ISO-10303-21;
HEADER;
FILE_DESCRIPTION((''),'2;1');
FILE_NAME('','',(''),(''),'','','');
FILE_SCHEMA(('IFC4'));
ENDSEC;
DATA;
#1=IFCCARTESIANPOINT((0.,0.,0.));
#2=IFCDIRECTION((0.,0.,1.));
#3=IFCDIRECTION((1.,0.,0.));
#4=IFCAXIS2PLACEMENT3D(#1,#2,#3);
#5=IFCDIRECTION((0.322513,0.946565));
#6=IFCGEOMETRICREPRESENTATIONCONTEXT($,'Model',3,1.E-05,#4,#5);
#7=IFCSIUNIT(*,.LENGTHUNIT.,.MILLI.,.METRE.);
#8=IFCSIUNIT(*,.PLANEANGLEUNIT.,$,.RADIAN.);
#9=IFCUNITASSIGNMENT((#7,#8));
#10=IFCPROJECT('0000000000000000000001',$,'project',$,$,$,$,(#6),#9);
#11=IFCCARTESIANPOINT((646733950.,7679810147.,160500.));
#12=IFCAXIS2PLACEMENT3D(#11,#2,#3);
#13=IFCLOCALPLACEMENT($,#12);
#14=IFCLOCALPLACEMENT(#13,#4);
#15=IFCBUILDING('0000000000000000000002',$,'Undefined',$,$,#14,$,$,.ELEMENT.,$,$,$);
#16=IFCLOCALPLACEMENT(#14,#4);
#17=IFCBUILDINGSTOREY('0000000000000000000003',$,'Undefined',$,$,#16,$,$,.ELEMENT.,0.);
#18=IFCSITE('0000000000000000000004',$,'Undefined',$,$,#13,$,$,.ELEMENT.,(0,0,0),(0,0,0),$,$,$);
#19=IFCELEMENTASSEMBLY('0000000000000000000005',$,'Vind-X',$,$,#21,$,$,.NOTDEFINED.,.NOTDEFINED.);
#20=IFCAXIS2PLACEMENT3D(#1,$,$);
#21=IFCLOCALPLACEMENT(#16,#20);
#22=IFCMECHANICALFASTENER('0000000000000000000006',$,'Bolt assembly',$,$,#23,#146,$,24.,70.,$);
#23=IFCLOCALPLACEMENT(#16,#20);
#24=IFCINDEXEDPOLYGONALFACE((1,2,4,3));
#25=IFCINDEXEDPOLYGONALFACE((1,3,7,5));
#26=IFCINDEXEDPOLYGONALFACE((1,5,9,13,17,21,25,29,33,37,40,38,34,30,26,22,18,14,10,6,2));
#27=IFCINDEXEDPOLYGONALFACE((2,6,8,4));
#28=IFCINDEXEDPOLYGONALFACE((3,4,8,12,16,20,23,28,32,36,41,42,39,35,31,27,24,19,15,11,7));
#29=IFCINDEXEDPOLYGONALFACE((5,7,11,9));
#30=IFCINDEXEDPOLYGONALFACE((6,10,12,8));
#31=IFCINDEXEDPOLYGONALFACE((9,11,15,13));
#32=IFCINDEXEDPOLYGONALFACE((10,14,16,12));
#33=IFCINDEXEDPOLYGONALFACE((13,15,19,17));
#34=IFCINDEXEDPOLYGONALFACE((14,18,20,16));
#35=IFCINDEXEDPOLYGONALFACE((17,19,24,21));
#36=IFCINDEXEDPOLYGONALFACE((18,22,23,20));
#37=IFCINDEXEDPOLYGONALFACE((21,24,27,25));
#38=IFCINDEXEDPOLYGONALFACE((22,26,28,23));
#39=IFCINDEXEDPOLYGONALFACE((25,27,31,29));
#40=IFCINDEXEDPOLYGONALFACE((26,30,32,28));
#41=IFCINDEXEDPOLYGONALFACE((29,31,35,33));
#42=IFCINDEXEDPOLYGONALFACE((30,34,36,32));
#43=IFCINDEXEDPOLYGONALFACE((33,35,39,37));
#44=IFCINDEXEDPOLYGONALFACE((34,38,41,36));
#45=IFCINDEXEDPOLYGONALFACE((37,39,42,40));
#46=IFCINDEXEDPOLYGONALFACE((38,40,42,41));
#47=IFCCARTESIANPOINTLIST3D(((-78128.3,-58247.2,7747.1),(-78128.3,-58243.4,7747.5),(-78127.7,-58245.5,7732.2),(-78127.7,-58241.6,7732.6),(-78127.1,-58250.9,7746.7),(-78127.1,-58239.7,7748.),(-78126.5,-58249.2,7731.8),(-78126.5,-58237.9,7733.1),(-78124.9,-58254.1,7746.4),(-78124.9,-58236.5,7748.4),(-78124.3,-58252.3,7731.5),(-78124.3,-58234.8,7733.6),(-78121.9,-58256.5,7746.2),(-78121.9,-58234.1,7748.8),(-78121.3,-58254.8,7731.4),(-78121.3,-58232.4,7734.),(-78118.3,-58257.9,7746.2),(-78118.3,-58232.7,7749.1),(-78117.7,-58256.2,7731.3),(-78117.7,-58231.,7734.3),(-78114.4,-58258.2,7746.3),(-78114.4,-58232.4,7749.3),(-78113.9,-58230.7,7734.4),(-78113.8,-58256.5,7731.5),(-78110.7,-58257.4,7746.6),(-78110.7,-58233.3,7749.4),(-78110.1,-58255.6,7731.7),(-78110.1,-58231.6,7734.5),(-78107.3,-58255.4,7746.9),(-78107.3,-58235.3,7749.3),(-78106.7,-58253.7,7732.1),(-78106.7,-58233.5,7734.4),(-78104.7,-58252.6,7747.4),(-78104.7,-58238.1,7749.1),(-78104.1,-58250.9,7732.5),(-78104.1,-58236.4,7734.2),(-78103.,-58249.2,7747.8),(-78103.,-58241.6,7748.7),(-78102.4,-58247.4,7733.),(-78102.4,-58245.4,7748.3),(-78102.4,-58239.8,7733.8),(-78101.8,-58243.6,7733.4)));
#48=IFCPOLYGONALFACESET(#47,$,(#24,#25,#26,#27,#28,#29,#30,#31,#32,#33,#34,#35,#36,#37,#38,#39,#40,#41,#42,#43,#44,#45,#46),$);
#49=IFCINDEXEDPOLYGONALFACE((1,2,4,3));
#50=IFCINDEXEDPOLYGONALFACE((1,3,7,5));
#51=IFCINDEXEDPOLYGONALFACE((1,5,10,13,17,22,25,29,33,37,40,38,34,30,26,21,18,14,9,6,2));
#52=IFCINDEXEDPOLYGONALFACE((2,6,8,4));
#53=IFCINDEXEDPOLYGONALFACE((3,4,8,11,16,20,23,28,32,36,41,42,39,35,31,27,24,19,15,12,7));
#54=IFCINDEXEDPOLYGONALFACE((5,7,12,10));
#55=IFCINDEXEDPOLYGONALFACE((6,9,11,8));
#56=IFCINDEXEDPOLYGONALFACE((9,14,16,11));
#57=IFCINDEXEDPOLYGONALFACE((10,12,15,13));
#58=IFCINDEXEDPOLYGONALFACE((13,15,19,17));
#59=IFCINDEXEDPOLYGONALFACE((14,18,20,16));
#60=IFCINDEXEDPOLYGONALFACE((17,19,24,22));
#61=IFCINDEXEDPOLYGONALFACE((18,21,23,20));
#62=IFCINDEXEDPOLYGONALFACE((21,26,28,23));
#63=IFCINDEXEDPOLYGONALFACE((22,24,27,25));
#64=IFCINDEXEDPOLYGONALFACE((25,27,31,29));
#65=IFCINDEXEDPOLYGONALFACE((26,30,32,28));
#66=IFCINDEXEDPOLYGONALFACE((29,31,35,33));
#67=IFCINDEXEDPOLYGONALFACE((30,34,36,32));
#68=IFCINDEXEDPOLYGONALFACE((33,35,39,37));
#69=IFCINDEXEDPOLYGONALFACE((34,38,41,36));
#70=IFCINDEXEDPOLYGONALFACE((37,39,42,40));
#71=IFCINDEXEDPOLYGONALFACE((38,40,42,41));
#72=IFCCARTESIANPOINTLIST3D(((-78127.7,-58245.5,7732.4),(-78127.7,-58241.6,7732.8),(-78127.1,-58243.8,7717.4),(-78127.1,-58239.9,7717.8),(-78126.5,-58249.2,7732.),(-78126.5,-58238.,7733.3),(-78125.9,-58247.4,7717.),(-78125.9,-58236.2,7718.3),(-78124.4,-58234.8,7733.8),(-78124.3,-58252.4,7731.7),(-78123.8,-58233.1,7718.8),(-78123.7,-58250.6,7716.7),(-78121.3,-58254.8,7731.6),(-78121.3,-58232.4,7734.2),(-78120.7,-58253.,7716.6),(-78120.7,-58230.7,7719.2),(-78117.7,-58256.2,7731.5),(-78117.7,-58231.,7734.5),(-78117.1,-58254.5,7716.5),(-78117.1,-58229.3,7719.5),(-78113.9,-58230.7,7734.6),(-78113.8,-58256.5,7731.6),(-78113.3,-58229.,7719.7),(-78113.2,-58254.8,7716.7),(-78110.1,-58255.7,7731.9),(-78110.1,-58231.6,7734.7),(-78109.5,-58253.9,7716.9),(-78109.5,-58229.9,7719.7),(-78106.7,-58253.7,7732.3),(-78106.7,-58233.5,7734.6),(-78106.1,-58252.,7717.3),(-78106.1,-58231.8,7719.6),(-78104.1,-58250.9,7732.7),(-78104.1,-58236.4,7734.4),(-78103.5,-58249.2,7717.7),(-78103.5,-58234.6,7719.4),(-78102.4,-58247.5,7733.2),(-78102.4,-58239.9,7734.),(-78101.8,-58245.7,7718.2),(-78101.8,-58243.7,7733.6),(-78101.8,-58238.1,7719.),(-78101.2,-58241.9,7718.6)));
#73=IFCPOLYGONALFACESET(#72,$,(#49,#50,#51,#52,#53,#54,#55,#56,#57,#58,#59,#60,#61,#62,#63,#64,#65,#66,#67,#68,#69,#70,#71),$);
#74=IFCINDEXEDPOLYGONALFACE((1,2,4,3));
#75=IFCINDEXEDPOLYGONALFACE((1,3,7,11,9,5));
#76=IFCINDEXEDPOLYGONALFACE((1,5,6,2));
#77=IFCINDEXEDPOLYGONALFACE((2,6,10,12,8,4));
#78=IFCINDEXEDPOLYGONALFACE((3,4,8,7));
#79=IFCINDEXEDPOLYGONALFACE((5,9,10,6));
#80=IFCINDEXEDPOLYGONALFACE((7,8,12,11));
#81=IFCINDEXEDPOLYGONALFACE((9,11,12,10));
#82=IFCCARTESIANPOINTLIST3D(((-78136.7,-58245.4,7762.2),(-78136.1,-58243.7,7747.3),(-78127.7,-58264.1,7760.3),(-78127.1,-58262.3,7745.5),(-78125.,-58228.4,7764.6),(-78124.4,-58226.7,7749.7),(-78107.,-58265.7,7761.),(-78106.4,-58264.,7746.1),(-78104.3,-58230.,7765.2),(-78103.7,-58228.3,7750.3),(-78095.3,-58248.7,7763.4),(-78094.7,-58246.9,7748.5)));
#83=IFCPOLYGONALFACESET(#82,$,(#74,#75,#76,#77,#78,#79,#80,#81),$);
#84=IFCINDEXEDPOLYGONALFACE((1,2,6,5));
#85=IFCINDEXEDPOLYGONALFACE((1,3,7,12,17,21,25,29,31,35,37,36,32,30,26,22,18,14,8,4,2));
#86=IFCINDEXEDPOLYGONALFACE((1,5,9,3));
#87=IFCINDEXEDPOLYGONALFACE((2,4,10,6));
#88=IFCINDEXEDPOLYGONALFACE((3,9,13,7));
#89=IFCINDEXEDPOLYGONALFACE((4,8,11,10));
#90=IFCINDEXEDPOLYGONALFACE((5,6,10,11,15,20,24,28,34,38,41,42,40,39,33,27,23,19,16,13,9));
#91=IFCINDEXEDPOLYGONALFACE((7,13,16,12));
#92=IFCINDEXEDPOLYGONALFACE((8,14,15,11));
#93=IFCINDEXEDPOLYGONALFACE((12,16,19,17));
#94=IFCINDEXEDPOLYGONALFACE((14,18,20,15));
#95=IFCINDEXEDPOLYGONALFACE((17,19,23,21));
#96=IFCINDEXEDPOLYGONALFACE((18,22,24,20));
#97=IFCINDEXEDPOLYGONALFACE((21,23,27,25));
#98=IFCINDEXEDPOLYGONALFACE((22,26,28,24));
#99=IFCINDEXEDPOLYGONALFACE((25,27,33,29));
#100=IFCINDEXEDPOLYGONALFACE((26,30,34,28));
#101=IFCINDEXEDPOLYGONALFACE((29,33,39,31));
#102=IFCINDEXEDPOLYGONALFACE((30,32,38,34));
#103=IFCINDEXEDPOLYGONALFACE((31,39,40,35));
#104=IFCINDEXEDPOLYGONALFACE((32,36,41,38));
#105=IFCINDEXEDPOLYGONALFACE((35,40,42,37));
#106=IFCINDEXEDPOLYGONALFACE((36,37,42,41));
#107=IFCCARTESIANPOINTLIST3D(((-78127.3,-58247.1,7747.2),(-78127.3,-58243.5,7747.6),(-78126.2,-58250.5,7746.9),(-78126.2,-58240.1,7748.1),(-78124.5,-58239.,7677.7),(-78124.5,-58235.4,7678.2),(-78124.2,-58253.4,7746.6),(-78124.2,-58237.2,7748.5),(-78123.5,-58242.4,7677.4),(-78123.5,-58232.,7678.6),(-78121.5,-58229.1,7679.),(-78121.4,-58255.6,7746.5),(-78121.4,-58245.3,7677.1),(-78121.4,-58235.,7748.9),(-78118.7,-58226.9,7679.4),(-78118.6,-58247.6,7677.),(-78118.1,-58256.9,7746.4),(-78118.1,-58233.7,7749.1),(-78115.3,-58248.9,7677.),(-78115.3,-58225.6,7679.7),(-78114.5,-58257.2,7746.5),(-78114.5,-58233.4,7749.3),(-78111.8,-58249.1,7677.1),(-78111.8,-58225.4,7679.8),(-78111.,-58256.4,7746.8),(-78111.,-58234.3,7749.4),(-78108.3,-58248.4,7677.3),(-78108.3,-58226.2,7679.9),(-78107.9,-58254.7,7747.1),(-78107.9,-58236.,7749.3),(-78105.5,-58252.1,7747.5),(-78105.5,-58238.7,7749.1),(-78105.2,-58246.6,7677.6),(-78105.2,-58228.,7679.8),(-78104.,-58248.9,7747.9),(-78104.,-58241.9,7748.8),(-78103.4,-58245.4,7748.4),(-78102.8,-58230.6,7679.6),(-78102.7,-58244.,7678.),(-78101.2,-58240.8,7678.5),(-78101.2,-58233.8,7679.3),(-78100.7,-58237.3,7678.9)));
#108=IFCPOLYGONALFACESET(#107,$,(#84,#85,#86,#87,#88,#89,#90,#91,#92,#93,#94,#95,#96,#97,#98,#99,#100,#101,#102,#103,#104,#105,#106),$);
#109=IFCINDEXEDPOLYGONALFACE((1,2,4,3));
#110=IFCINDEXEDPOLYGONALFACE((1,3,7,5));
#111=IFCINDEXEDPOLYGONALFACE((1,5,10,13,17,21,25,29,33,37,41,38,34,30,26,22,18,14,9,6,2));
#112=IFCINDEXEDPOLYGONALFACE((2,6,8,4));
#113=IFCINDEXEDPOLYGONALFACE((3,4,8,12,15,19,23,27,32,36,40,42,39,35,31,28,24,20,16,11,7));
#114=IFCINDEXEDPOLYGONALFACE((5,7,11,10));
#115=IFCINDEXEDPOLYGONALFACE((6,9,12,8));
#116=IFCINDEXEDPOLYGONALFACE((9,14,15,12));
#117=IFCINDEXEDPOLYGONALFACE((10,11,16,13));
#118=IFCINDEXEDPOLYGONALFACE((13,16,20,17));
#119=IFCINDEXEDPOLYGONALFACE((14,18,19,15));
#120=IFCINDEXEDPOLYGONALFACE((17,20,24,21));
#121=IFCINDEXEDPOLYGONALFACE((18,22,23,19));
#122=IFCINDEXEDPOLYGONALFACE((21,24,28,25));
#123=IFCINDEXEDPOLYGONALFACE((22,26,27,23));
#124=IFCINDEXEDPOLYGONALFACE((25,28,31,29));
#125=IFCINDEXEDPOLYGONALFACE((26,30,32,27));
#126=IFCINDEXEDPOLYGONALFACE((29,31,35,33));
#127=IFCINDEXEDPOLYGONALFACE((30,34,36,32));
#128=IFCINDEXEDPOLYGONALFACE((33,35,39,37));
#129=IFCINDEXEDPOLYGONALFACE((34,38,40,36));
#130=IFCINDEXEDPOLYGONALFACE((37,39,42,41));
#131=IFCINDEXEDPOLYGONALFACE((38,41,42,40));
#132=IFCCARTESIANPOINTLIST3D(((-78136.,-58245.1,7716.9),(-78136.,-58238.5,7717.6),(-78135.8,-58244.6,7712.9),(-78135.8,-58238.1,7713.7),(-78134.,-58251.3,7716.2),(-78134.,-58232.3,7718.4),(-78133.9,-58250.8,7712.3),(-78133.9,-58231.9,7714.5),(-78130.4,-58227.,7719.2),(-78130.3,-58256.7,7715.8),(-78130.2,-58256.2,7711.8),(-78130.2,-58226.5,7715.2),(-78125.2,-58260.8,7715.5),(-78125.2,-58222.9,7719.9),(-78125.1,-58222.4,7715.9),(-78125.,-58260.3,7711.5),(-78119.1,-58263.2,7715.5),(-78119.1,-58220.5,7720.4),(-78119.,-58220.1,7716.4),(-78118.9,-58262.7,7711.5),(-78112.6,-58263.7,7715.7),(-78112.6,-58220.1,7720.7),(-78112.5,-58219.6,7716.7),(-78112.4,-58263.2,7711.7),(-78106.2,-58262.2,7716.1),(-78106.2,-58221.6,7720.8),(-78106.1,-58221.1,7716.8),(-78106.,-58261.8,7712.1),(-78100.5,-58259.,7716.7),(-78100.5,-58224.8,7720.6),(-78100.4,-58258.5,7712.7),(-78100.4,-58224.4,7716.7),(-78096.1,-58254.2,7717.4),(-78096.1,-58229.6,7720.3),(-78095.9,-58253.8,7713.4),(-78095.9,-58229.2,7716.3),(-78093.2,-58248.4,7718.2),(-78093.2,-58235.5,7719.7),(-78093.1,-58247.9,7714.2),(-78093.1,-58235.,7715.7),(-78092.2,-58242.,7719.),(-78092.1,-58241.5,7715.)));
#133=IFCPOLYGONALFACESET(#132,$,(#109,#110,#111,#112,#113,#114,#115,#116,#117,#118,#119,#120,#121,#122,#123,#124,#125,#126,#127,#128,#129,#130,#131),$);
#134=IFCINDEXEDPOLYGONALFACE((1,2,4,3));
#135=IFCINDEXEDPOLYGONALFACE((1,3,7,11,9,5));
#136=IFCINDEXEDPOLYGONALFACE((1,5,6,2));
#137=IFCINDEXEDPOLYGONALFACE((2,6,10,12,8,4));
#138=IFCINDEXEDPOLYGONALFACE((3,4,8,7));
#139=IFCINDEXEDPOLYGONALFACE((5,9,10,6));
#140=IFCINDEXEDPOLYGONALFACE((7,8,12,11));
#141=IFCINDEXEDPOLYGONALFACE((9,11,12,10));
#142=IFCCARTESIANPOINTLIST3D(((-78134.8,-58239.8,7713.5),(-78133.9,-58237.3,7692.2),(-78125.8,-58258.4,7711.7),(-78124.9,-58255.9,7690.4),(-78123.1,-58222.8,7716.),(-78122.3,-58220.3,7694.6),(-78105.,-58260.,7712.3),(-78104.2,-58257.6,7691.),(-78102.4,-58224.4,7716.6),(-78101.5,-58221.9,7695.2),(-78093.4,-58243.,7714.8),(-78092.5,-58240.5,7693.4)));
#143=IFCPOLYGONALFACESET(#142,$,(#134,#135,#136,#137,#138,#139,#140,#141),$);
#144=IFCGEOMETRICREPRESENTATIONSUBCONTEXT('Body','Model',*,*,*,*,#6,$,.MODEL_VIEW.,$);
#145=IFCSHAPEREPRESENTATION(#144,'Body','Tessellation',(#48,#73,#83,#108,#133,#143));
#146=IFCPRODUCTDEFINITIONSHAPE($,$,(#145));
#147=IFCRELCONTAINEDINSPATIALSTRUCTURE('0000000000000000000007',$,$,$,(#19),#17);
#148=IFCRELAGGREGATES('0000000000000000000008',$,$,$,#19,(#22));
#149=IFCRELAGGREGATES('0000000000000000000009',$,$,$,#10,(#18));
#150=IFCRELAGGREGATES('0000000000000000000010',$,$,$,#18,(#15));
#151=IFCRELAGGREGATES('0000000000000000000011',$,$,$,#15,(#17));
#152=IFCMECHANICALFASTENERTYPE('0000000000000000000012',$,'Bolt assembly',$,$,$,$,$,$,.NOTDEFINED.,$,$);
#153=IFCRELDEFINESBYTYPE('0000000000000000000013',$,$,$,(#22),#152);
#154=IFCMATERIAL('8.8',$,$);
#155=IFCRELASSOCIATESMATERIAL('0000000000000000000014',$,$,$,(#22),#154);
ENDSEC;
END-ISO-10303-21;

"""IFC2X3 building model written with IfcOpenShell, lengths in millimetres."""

from ifc_helpers import new_model, si_unit, direction, frame, origin_with_axes, origin_2d_with_axis, place, context, subcontext, project, spatial, polyline, circle, outline, extrude, source, transform, mapped, material, type_object, element, aggregate, save


model = new_model("IFC2X3")

# Units and contexts
model_context = context("Model", 3, precision=1e-05, world=origin_with_axes(), true_north=direction((0.322513, 0.946565)))
body_context = subcontext(model_context, "Body", "Model", "MODEL_VIEW")
ifc_project = project(units=[si_unit("LENGTHUNIT", "METRE", prefix="MILLI"), si_unit("PLANEANGLEUNIT", "RADIAN")], contexts=[model_context])

# Site, building, storey
site_placement = place(None, frame((646733950.0, 7679810147.0, 160500.0), z_axis=(0.0, 0.0, 1.0), x_axis=(1.0, 0.0, 0.0)))
site = spatial("IfcSite", under=ifc_project, at=site_placement, Name="Undefined", CompositionType="ELEMENT", RefLatitude=(0, 0, 0), RefLongitude=(0, 0, 0))
building_placement = place(site_placement, origin_with_axes())
building = spatial("IfcBuilding", under=site, at=building_placement, Name="Undefined", CompositionType="ELEMENT")
storey_placement = place(building_placement, origin_with_axes())
storey = spatial("IfcBuildingStorey", under=building, at=storey_placement, Name="Undefined", CompositionType="ELEMENT", Elevation=0.0)

# Element assembly
assembly_1_placement = place(storey_placement, origin_with_axes())
assembly_1 = element("IfcElementAssembly", 1, at=assembly_1_placement, inside=storey, Name="Vind-X", AssemblyPlace="NOTDEFINED", PredefinedType="NOTDEFINED")

# Mechanical fastener
ifc_material_1 = material(Name="8.8")
mechanical_fastener_type = type_object("IfcMechanicalFastenerType", Name="Bolt assembly")
shared_shape_1 = source(origin_with_axes(), body_context, "Body", "SweptSolid", [
    extrude(circle(Radius=13.0, at=origin_2d_with_axis()), frame((0.0, -22.4, 0.0), z_axis=(0.0, 1.0, 0.0), x_axis=(1.0, 0.0, 0.0)), (0.0, 0.0, 1.0), 15.0),
    extrude(circle(Radius=13.0, at=origin_2d_with_axis()), frame((0.0, -7.6, 0.0), z_axis=(0.0, 1.0, 0.0), x_axis=(1.0, 0.0, 0.0)), (0.0, 0.0, 1.0), 15.1),
    extrude(outline(polyline([(18.0, -10.4), (18.0, 10.4), (0.0, 20.8), (-18.0, 10.4), (-18.0, -10.4), (0.0, -20.8), (18.0, -10.4)])), frame((0.0, -37.5, 0.0), z_axis=(0.0, 1.0, 0.0), x_axis=(1.0, 0.0, 0.0)), (0.0, 0.0, 1.0), 15.0),
    extrude(circle(Radius=12.0, at=origin_2d_with_axis()), frame((0.0, -22.5, 0.0), z_axis=(0.0, 1.0, 0.0), x_axis=(1.0, 0.0, 0.0)), (0.0, 0.0, 1.0), 70.0),
    extrude(circle(Radius=22.0, at=origin_2d_with_axis()), frame((0.0, 7.5, 0.0), z_axis=(0.0, 1.0, 0.0), x_axis=(1.0, 0.0, 0.0)), (0.0, 0.0, 1.0), 4.0),
    extrude(outline(polyline([(18.0, -10.4), (18.0, 10.4), (0.0, 20.8), (-18.0, 10.4), (-18.0, -10.4), (0.0, -20.8), (18.0, -10.4)])), frame((0.0, 11.5, 0.0), z_axis=(0.0, 1.0, 0.0), x_axis=(1.0, 0.0, 0.0)), (0.0, 0.0, 1.0), 21.5),
])
mechanical_fastener_1_placement = place(assembly_1_placement, frame((-78114.5, -58242.7, 7725.6), z_axis=(0.434441, -0.89649, -0.08699), x_axis=(-0.899843, -0.427783, -0.085352)))
mechanical_fastener_1 = element("IfcMechanicalFastener", 2, at=mechanical_fastener_1_placement, type_object=mechanical_fastener_type, material=ifc_material_1, Name="Bolt assembly", NominalDiameter=24.0, NominalLength=70.0, context=body_context, shape_type="MappedRepresentation", body=[
    mapped(shared_shape_1, transform((0.0, 0.0, 0.0))),
])
aggregate(assembly_1, [mechanical_fastener_1])

save(model, "model.ifc")
